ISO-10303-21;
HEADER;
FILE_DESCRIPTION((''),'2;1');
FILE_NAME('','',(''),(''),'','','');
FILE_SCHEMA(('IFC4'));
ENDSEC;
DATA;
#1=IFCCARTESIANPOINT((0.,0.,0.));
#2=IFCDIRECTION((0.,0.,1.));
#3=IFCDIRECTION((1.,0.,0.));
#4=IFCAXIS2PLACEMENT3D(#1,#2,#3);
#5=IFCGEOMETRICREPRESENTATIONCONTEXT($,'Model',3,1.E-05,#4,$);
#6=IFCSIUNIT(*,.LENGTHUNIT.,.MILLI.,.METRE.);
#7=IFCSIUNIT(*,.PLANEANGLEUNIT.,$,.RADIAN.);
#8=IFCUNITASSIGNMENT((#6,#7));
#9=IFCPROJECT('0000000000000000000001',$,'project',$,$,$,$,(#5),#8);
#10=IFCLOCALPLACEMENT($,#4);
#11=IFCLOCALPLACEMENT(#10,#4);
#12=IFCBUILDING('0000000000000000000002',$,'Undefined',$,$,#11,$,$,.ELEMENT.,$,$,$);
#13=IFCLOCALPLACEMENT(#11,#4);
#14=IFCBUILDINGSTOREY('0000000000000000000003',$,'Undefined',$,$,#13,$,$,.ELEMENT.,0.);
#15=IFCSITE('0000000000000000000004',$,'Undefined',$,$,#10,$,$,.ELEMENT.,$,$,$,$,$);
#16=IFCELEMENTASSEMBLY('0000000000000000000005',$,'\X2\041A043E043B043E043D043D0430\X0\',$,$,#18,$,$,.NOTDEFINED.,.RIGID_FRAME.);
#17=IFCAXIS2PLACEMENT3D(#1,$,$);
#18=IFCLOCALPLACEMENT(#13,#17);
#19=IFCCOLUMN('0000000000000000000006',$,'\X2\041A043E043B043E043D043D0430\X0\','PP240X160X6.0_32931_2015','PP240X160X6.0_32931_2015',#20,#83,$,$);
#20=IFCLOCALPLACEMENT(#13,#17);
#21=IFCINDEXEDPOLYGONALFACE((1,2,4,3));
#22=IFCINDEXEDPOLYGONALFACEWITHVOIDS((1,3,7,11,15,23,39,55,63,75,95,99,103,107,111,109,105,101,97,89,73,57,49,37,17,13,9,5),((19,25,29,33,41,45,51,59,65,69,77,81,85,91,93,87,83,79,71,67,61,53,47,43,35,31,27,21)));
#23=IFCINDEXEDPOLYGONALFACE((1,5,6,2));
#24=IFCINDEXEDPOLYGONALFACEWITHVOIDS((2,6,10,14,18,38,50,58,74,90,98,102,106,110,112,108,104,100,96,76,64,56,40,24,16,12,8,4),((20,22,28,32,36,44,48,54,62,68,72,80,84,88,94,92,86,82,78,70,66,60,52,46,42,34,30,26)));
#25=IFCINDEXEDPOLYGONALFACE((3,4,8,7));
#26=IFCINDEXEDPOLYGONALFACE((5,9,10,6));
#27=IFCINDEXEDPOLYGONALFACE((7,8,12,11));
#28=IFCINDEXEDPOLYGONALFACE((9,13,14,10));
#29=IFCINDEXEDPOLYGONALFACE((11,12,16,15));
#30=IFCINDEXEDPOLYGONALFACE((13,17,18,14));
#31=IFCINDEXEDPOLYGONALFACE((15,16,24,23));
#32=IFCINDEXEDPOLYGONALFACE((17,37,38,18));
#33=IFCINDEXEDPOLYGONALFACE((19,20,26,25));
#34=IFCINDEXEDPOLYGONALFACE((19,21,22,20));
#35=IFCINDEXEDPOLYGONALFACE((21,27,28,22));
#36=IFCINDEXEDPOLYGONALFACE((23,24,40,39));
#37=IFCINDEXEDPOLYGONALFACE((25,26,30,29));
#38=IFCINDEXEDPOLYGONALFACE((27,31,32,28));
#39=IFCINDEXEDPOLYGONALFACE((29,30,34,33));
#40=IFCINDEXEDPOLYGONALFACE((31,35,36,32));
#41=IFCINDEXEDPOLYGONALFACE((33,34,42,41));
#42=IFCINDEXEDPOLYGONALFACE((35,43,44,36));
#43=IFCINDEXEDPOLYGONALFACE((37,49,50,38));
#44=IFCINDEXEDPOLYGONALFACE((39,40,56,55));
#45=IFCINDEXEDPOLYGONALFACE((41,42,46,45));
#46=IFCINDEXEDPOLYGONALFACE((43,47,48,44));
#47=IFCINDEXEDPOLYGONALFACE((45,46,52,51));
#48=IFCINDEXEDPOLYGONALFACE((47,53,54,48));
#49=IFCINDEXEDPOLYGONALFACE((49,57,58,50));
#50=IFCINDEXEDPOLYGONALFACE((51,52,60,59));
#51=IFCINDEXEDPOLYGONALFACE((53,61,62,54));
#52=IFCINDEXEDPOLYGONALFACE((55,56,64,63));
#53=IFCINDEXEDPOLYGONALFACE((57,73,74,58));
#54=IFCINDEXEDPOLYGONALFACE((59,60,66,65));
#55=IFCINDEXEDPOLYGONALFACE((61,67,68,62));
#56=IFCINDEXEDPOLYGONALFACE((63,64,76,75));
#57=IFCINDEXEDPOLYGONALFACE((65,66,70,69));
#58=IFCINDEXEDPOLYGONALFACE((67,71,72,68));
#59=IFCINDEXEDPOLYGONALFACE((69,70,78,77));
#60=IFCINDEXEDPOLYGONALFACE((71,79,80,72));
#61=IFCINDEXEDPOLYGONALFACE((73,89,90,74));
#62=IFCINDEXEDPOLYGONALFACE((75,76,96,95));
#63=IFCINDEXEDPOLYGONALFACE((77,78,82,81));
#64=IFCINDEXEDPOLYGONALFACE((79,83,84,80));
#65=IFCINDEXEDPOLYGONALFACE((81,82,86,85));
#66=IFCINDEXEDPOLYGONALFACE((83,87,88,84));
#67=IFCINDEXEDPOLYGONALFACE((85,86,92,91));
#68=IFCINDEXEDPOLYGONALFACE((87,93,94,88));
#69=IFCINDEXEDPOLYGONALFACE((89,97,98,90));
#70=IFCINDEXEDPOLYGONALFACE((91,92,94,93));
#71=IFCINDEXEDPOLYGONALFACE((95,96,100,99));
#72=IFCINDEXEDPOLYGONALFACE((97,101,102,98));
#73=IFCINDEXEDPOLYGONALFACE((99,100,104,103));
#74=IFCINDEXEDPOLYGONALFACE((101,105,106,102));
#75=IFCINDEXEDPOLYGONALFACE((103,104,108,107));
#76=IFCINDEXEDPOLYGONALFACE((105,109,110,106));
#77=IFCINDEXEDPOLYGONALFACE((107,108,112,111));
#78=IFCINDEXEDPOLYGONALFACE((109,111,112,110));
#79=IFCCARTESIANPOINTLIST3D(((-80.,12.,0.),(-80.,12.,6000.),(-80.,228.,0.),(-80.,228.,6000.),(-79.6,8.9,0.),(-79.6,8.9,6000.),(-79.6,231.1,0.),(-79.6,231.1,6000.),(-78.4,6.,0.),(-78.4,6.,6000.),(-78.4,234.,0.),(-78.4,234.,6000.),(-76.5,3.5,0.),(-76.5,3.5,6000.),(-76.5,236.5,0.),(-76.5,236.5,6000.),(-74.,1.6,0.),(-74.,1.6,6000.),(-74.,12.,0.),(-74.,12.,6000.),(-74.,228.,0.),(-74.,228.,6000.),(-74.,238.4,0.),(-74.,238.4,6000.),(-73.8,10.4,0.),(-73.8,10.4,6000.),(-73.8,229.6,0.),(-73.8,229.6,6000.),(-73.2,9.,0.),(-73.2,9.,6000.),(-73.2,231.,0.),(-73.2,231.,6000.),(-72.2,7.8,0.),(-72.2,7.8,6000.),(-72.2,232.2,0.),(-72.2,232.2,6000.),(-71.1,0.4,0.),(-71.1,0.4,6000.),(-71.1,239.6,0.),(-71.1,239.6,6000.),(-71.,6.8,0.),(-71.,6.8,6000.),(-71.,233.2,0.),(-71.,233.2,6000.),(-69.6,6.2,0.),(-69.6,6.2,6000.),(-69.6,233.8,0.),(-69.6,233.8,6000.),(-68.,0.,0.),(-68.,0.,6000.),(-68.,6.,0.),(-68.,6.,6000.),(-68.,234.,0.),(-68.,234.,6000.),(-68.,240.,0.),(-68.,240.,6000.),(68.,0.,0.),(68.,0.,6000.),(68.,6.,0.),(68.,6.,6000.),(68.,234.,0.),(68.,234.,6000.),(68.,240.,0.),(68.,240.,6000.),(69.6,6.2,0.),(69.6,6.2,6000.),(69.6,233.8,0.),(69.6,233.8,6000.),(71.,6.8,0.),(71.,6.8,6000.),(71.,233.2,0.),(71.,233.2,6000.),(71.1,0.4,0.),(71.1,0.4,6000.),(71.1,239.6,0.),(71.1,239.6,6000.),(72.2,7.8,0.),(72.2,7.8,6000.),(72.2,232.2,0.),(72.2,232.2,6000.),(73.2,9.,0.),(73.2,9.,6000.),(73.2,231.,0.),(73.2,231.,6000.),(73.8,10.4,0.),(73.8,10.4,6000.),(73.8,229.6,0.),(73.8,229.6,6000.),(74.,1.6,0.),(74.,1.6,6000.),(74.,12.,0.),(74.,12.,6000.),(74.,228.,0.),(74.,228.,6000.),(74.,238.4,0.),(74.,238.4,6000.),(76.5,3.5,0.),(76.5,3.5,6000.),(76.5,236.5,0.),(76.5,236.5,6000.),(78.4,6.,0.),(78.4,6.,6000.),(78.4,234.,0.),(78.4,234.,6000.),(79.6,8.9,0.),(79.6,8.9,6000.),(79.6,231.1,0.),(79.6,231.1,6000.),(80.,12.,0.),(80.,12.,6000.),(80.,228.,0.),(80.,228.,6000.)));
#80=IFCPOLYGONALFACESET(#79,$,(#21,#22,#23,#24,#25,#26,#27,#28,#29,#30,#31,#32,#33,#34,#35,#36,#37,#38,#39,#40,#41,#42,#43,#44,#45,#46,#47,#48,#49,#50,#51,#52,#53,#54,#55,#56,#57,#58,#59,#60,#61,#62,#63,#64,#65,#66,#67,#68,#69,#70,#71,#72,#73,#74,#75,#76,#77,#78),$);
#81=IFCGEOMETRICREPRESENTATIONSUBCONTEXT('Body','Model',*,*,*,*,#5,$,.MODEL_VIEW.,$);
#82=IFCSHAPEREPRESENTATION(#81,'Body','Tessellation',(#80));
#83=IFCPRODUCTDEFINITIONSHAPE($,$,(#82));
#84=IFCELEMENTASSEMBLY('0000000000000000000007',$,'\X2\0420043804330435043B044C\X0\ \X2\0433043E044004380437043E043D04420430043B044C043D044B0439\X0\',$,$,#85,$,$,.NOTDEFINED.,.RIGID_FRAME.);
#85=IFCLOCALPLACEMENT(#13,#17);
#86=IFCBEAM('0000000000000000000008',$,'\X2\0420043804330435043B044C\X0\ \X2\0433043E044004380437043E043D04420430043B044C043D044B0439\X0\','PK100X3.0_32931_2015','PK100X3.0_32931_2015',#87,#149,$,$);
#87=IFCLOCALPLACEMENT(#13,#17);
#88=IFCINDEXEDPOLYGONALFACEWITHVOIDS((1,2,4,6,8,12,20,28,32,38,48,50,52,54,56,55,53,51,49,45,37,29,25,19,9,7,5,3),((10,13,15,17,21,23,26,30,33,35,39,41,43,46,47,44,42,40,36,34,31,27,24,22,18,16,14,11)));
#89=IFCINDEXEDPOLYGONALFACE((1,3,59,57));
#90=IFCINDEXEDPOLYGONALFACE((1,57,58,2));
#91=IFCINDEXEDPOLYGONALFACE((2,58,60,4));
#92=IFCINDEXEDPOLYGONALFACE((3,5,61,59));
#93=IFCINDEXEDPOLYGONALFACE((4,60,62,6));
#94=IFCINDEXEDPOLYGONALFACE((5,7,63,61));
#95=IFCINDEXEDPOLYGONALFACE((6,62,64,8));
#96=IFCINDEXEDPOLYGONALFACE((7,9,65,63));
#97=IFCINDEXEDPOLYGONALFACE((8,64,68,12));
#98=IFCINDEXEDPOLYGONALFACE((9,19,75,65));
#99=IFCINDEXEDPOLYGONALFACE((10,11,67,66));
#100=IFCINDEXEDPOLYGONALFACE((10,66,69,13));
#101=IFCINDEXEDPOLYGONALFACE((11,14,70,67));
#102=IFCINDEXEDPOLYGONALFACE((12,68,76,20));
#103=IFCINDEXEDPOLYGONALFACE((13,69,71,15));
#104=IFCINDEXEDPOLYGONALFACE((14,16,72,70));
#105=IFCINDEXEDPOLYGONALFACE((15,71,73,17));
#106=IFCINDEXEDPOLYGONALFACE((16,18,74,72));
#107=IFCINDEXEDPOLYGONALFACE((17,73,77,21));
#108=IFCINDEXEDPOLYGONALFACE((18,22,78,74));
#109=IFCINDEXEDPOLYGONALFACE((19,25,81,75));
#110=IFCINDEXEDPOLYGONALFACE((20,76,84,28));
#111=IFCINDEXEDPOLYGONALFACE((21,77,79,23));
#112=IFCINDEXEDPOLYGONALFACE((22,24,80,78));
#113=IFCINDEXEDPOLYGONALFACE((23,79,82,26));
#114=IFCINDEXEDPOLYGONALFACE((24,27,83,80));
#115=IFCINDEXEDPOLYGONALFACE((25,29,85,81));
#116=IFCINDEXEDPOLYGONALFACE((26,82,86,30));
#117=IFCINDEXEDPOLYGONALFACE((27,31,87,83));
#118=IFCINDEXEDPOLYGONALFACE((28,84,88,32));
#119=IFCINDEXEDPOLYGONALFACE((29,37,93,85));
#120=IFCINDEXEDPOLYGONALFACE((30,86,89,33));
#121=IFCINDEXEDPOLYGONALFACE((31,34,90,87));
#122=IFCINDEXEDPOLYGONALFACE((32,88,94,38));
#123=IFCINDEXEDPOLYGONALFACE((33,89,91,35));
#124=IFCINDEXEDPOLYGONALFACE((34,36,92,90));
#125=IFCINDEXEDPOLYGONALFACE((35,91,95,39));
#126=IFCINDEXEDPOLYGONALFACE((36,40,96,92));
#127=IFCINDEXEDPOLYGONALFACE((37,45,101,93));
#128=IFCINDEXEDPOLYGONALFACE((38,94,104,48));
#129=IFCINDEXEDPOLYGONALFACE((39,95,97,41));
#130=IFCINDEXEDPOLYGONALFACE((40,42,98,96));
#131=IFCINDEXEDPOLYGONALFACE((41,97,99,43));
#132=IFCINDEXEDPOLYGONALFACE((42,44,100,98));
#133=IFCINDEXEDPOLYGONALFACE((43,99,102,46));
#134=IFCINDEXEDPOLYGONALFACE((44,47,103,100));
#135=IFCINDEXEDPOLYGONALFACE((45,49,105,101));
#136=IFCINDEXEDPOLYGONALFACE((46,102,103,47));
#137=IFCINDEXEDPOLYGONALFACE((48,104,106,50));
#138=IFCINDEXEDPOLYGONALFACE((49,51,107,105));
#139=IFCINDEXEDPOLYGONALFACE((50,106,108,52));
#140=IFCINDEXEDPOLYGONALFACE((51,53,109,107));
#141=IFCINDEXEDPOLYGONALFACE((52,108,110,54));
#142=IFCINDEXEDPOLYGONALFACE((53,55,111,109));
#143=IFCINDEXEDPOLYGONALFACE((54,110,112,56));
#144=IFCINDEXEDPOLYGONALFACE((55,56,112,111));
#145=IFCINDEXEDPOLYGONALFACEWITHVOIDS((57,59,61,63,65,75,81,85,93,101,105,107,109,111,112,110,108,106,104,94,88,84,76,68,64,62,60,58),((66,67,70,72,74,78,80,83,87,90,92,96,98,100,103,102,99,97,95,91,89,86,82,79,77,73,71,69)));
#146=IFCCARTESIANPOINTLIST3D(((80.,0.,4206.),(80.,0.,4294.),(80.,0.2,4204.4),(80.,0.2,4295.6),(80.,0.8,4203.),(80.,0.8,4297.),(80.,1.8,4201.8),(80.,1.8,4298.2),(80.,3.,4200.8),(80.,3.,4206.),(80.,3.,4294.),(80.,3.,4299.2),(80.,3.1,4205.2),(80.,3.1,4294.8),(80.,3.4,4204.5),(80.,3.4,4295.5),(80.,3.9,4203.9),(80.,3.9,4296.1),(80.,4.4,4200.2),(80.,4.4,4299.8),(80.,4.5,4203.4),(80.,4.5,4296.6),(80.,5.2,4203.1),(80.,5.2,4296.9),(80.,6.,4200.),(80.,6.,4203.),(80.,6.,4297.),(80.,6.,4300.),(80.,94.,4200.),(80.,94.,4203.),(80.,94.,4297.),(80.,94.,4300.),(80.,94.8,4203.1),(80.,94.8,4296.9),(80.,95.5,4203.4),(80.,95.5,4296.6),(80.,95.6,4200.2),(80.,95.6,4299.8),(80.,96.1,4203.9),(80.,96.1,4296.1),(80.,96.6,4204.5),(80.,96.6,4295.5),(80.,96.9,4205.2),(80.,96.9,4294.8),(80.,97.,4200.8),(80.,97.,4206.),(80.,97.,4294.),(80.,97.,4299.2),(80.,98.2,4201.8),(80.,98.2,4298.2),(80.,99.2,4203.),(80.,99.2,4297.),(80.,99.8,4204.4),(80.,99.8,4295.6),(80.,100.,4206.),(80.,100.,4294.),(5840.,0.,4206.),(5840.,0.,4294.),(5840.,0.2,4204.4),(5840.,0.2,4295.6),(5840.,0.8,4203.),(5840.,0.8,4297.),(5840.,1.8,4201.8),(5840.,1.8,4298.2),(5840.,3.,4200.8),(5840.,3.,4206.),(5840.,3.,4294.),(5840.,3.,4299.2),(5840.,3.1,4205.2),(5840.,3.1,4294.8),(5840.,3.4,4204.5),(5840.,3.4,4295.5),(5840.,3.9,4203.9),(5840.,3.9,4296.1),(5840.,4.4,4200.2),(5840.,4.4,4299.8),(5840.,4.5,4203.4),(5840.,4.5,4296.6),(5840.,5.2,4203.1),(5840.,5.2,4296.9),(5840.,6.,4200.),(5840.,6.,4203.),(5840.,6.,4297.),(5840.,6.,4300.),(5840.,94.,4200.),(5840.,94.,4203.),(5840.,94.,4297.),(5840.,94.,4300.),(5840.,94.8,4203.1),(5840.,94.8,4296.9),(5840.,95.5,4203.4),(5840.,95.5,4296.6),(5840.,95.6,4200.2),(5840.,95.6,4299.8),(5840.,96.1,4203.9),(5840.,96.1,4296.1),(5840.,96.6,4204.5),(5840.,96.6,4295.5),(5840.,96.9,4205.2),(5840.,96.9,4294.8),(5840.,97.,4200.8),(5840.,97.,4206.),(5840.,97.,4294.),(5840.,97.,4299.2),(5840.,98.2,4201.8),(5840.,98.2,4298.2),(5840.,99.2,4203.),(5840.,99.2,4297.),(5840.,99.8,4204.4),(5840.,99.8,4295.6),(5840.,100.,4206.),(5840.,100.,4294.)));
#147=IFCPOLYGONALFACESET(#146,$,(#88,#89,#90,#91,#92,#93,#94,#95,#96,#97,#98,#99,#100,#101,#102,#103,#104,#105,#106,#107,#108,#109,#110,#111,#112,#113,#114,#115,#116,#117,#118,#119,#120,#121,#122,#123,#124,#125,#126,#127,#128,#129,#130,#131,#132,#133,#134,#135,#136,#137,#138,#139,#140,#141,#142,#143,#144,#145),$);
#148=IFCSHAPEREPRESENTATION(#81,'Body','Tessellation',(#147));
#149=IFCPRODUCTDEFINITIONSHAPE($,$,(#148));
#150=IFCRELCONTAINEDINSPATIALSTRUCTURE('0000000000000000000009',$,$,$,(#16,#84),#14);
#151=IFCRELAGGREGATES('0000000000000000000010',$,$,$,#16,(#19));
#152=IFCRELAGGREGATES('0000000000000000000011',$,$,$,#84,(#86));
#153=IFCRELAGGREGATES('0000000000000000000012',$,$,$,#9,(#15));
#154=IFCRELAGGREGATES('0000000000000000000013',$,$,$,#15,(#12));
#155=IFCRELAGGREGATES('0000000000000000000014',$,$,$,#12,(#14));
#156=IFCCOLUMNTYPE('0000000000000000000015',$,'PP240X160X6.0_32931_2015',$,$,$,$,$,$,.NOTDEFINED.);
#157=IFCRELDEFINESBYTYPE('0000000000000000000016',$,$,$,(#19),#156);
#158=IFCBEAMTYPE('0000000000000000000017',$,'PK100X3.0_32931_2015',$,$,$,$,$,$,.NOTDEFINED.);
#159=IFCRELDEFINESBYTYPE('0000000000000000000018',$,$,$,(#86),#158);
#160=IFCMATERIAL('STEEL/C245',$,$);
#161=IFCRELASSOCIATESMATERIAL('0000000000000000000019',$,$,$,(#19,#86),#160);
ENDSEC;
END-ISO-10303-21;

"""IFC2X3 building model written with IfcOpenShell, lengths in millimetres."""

from ifc_helpers import new_model, si_unit, frame, origin_with_axes, origin_2d_with_axis, place, context, subcontext, project, spatial, hollow_rectangle, extrude, material, type_object, element, aggregate, save


model = new_model("IFC2X3")

# Units and contexts
model_context = context("Model", 3, precision=1e-05, world=origin_with_axes())
body_context = subcontext(model_context, "Body", "Model", "MODEL_VIEW")
ifc_project = project(units=[si_unit("LENGTHUNIT", "METRE", prefix="MILLI"), si_unit("PLANEANGLEUNIT", "RADIAN")], contexts=[model_context])

# Site, building, storey
site_placement = place(None, origin_with_axes())
site = spatial("IfcSite", under=ifc_project, at=site_placement, Name="Undefined", CompositionType="ELEMENT")
building_placement = place(site_placement, origin_with_axes())
building = spatial("IfcBuilding", under=site, at=building_placement, Name="Undefined", CompositionType="ELEMENT")
storey_placement = place(building_placement, origin_with_axes())
storey = spatial("IfcBuildingStorey", under=building, at=storey_placement, Name="Undefined", CompositionType="ELEMENT", Elevation=0.0)

# Element assembly, column
assembly_1_placement = place(storey_placement, origin_with_axes())
assembly_1 = element("IfcElementAssembly", 1, at=assembly_1_placement, inside=storey, Name="Колонна", AssemblyPlace="NOTDEFINED", PredefinedType="RIGID_FRAME")
ifc_material = material(Name="STEEL/C245")
column_type = type_object("IfcColumnType", Name="PP240X160X6.0_32931_2015", PredefinedType="NOTDEFINED")
column_placement = place(assembly_1_placement, frame((0.0, 120.0, 0.0), z_axis=(0.0, 0.0, 1.0), x_axis=(0.0, 1.0, 0.0)))
column = element("IfcColumn", 2, at=column_placement, type_object=column_type, material=ifc_material, Name="Колонна", Description="PP240X160X6.0_32931_2015", ObjectType="PP240X160X6.0_32931_2015", context=body_context, shape_type="SweptSolid", body=[
    extrude(hollow_rectangle(XDim=160.0, YDim=240.0, WallThickness=6.0, InnerFilletRadius=6.0, OuterFilletRadius=12.0, at=origin_2d_with_axis()), frame((0.0, 0.0, 6000.0), z_axis=(0.0, 0.0, -1.0), x_axis=(0.0, 1.0, 0.0)), (0.0, 0.0, 1.0), 6000.0),
])
aggregate(assembly_1, [column])

# Element assembly, beam
assembly_2_placement = place(storey_placement, origin_with_axes())
assembly_2 = element("IfcElementAssembly", 3, at=assembly_2_placement, inside=storey, Name="Ригель горизонтальный", AssemblyPlace="NOTDEFINED", PredefinedType="RIGID_FRAME")
beam_type_1 = type_object("IfcBeamType", Name="PK100X3.0_32931_2015", PredefinedType="NOTDEFINED")
beam_1_placement = place(assembly_2_placement, frame((80.0, 50.0, 4250.0), z_axis=(0.0, 0.0, 1.0), x_axis=(1.0, 0.0, 0.0)))
beam_1 = element("IfcBeam", 4, at=beam_1_placement, type_object=beam_type_1, material=ifc_material, Name="Ригель горизонтальный", Description="PK100X3.0_32931_2015", ObjectType="PK100X3.0_32931_2015", context=body_context, shape_type="SweptSolid", body=[
    extrude(hollow_rectangle(XDim=100.0, YDim=100.0, WallThickness=3.0, InnerFilletRadius=3.0, OuterFilletRadius=6.0, at=origin_2d_with_axis()), frame((5760.0, 0.0, 0.0), z_axis=(-1.0, 0.0, 0.0), x_axis=(0.0, -1.0, 0.0)), (0.0, 0.0, 1.0), 5760.0),
])
aggregate(assembly_2, [beam_1])

save(model, "model.ifc")
